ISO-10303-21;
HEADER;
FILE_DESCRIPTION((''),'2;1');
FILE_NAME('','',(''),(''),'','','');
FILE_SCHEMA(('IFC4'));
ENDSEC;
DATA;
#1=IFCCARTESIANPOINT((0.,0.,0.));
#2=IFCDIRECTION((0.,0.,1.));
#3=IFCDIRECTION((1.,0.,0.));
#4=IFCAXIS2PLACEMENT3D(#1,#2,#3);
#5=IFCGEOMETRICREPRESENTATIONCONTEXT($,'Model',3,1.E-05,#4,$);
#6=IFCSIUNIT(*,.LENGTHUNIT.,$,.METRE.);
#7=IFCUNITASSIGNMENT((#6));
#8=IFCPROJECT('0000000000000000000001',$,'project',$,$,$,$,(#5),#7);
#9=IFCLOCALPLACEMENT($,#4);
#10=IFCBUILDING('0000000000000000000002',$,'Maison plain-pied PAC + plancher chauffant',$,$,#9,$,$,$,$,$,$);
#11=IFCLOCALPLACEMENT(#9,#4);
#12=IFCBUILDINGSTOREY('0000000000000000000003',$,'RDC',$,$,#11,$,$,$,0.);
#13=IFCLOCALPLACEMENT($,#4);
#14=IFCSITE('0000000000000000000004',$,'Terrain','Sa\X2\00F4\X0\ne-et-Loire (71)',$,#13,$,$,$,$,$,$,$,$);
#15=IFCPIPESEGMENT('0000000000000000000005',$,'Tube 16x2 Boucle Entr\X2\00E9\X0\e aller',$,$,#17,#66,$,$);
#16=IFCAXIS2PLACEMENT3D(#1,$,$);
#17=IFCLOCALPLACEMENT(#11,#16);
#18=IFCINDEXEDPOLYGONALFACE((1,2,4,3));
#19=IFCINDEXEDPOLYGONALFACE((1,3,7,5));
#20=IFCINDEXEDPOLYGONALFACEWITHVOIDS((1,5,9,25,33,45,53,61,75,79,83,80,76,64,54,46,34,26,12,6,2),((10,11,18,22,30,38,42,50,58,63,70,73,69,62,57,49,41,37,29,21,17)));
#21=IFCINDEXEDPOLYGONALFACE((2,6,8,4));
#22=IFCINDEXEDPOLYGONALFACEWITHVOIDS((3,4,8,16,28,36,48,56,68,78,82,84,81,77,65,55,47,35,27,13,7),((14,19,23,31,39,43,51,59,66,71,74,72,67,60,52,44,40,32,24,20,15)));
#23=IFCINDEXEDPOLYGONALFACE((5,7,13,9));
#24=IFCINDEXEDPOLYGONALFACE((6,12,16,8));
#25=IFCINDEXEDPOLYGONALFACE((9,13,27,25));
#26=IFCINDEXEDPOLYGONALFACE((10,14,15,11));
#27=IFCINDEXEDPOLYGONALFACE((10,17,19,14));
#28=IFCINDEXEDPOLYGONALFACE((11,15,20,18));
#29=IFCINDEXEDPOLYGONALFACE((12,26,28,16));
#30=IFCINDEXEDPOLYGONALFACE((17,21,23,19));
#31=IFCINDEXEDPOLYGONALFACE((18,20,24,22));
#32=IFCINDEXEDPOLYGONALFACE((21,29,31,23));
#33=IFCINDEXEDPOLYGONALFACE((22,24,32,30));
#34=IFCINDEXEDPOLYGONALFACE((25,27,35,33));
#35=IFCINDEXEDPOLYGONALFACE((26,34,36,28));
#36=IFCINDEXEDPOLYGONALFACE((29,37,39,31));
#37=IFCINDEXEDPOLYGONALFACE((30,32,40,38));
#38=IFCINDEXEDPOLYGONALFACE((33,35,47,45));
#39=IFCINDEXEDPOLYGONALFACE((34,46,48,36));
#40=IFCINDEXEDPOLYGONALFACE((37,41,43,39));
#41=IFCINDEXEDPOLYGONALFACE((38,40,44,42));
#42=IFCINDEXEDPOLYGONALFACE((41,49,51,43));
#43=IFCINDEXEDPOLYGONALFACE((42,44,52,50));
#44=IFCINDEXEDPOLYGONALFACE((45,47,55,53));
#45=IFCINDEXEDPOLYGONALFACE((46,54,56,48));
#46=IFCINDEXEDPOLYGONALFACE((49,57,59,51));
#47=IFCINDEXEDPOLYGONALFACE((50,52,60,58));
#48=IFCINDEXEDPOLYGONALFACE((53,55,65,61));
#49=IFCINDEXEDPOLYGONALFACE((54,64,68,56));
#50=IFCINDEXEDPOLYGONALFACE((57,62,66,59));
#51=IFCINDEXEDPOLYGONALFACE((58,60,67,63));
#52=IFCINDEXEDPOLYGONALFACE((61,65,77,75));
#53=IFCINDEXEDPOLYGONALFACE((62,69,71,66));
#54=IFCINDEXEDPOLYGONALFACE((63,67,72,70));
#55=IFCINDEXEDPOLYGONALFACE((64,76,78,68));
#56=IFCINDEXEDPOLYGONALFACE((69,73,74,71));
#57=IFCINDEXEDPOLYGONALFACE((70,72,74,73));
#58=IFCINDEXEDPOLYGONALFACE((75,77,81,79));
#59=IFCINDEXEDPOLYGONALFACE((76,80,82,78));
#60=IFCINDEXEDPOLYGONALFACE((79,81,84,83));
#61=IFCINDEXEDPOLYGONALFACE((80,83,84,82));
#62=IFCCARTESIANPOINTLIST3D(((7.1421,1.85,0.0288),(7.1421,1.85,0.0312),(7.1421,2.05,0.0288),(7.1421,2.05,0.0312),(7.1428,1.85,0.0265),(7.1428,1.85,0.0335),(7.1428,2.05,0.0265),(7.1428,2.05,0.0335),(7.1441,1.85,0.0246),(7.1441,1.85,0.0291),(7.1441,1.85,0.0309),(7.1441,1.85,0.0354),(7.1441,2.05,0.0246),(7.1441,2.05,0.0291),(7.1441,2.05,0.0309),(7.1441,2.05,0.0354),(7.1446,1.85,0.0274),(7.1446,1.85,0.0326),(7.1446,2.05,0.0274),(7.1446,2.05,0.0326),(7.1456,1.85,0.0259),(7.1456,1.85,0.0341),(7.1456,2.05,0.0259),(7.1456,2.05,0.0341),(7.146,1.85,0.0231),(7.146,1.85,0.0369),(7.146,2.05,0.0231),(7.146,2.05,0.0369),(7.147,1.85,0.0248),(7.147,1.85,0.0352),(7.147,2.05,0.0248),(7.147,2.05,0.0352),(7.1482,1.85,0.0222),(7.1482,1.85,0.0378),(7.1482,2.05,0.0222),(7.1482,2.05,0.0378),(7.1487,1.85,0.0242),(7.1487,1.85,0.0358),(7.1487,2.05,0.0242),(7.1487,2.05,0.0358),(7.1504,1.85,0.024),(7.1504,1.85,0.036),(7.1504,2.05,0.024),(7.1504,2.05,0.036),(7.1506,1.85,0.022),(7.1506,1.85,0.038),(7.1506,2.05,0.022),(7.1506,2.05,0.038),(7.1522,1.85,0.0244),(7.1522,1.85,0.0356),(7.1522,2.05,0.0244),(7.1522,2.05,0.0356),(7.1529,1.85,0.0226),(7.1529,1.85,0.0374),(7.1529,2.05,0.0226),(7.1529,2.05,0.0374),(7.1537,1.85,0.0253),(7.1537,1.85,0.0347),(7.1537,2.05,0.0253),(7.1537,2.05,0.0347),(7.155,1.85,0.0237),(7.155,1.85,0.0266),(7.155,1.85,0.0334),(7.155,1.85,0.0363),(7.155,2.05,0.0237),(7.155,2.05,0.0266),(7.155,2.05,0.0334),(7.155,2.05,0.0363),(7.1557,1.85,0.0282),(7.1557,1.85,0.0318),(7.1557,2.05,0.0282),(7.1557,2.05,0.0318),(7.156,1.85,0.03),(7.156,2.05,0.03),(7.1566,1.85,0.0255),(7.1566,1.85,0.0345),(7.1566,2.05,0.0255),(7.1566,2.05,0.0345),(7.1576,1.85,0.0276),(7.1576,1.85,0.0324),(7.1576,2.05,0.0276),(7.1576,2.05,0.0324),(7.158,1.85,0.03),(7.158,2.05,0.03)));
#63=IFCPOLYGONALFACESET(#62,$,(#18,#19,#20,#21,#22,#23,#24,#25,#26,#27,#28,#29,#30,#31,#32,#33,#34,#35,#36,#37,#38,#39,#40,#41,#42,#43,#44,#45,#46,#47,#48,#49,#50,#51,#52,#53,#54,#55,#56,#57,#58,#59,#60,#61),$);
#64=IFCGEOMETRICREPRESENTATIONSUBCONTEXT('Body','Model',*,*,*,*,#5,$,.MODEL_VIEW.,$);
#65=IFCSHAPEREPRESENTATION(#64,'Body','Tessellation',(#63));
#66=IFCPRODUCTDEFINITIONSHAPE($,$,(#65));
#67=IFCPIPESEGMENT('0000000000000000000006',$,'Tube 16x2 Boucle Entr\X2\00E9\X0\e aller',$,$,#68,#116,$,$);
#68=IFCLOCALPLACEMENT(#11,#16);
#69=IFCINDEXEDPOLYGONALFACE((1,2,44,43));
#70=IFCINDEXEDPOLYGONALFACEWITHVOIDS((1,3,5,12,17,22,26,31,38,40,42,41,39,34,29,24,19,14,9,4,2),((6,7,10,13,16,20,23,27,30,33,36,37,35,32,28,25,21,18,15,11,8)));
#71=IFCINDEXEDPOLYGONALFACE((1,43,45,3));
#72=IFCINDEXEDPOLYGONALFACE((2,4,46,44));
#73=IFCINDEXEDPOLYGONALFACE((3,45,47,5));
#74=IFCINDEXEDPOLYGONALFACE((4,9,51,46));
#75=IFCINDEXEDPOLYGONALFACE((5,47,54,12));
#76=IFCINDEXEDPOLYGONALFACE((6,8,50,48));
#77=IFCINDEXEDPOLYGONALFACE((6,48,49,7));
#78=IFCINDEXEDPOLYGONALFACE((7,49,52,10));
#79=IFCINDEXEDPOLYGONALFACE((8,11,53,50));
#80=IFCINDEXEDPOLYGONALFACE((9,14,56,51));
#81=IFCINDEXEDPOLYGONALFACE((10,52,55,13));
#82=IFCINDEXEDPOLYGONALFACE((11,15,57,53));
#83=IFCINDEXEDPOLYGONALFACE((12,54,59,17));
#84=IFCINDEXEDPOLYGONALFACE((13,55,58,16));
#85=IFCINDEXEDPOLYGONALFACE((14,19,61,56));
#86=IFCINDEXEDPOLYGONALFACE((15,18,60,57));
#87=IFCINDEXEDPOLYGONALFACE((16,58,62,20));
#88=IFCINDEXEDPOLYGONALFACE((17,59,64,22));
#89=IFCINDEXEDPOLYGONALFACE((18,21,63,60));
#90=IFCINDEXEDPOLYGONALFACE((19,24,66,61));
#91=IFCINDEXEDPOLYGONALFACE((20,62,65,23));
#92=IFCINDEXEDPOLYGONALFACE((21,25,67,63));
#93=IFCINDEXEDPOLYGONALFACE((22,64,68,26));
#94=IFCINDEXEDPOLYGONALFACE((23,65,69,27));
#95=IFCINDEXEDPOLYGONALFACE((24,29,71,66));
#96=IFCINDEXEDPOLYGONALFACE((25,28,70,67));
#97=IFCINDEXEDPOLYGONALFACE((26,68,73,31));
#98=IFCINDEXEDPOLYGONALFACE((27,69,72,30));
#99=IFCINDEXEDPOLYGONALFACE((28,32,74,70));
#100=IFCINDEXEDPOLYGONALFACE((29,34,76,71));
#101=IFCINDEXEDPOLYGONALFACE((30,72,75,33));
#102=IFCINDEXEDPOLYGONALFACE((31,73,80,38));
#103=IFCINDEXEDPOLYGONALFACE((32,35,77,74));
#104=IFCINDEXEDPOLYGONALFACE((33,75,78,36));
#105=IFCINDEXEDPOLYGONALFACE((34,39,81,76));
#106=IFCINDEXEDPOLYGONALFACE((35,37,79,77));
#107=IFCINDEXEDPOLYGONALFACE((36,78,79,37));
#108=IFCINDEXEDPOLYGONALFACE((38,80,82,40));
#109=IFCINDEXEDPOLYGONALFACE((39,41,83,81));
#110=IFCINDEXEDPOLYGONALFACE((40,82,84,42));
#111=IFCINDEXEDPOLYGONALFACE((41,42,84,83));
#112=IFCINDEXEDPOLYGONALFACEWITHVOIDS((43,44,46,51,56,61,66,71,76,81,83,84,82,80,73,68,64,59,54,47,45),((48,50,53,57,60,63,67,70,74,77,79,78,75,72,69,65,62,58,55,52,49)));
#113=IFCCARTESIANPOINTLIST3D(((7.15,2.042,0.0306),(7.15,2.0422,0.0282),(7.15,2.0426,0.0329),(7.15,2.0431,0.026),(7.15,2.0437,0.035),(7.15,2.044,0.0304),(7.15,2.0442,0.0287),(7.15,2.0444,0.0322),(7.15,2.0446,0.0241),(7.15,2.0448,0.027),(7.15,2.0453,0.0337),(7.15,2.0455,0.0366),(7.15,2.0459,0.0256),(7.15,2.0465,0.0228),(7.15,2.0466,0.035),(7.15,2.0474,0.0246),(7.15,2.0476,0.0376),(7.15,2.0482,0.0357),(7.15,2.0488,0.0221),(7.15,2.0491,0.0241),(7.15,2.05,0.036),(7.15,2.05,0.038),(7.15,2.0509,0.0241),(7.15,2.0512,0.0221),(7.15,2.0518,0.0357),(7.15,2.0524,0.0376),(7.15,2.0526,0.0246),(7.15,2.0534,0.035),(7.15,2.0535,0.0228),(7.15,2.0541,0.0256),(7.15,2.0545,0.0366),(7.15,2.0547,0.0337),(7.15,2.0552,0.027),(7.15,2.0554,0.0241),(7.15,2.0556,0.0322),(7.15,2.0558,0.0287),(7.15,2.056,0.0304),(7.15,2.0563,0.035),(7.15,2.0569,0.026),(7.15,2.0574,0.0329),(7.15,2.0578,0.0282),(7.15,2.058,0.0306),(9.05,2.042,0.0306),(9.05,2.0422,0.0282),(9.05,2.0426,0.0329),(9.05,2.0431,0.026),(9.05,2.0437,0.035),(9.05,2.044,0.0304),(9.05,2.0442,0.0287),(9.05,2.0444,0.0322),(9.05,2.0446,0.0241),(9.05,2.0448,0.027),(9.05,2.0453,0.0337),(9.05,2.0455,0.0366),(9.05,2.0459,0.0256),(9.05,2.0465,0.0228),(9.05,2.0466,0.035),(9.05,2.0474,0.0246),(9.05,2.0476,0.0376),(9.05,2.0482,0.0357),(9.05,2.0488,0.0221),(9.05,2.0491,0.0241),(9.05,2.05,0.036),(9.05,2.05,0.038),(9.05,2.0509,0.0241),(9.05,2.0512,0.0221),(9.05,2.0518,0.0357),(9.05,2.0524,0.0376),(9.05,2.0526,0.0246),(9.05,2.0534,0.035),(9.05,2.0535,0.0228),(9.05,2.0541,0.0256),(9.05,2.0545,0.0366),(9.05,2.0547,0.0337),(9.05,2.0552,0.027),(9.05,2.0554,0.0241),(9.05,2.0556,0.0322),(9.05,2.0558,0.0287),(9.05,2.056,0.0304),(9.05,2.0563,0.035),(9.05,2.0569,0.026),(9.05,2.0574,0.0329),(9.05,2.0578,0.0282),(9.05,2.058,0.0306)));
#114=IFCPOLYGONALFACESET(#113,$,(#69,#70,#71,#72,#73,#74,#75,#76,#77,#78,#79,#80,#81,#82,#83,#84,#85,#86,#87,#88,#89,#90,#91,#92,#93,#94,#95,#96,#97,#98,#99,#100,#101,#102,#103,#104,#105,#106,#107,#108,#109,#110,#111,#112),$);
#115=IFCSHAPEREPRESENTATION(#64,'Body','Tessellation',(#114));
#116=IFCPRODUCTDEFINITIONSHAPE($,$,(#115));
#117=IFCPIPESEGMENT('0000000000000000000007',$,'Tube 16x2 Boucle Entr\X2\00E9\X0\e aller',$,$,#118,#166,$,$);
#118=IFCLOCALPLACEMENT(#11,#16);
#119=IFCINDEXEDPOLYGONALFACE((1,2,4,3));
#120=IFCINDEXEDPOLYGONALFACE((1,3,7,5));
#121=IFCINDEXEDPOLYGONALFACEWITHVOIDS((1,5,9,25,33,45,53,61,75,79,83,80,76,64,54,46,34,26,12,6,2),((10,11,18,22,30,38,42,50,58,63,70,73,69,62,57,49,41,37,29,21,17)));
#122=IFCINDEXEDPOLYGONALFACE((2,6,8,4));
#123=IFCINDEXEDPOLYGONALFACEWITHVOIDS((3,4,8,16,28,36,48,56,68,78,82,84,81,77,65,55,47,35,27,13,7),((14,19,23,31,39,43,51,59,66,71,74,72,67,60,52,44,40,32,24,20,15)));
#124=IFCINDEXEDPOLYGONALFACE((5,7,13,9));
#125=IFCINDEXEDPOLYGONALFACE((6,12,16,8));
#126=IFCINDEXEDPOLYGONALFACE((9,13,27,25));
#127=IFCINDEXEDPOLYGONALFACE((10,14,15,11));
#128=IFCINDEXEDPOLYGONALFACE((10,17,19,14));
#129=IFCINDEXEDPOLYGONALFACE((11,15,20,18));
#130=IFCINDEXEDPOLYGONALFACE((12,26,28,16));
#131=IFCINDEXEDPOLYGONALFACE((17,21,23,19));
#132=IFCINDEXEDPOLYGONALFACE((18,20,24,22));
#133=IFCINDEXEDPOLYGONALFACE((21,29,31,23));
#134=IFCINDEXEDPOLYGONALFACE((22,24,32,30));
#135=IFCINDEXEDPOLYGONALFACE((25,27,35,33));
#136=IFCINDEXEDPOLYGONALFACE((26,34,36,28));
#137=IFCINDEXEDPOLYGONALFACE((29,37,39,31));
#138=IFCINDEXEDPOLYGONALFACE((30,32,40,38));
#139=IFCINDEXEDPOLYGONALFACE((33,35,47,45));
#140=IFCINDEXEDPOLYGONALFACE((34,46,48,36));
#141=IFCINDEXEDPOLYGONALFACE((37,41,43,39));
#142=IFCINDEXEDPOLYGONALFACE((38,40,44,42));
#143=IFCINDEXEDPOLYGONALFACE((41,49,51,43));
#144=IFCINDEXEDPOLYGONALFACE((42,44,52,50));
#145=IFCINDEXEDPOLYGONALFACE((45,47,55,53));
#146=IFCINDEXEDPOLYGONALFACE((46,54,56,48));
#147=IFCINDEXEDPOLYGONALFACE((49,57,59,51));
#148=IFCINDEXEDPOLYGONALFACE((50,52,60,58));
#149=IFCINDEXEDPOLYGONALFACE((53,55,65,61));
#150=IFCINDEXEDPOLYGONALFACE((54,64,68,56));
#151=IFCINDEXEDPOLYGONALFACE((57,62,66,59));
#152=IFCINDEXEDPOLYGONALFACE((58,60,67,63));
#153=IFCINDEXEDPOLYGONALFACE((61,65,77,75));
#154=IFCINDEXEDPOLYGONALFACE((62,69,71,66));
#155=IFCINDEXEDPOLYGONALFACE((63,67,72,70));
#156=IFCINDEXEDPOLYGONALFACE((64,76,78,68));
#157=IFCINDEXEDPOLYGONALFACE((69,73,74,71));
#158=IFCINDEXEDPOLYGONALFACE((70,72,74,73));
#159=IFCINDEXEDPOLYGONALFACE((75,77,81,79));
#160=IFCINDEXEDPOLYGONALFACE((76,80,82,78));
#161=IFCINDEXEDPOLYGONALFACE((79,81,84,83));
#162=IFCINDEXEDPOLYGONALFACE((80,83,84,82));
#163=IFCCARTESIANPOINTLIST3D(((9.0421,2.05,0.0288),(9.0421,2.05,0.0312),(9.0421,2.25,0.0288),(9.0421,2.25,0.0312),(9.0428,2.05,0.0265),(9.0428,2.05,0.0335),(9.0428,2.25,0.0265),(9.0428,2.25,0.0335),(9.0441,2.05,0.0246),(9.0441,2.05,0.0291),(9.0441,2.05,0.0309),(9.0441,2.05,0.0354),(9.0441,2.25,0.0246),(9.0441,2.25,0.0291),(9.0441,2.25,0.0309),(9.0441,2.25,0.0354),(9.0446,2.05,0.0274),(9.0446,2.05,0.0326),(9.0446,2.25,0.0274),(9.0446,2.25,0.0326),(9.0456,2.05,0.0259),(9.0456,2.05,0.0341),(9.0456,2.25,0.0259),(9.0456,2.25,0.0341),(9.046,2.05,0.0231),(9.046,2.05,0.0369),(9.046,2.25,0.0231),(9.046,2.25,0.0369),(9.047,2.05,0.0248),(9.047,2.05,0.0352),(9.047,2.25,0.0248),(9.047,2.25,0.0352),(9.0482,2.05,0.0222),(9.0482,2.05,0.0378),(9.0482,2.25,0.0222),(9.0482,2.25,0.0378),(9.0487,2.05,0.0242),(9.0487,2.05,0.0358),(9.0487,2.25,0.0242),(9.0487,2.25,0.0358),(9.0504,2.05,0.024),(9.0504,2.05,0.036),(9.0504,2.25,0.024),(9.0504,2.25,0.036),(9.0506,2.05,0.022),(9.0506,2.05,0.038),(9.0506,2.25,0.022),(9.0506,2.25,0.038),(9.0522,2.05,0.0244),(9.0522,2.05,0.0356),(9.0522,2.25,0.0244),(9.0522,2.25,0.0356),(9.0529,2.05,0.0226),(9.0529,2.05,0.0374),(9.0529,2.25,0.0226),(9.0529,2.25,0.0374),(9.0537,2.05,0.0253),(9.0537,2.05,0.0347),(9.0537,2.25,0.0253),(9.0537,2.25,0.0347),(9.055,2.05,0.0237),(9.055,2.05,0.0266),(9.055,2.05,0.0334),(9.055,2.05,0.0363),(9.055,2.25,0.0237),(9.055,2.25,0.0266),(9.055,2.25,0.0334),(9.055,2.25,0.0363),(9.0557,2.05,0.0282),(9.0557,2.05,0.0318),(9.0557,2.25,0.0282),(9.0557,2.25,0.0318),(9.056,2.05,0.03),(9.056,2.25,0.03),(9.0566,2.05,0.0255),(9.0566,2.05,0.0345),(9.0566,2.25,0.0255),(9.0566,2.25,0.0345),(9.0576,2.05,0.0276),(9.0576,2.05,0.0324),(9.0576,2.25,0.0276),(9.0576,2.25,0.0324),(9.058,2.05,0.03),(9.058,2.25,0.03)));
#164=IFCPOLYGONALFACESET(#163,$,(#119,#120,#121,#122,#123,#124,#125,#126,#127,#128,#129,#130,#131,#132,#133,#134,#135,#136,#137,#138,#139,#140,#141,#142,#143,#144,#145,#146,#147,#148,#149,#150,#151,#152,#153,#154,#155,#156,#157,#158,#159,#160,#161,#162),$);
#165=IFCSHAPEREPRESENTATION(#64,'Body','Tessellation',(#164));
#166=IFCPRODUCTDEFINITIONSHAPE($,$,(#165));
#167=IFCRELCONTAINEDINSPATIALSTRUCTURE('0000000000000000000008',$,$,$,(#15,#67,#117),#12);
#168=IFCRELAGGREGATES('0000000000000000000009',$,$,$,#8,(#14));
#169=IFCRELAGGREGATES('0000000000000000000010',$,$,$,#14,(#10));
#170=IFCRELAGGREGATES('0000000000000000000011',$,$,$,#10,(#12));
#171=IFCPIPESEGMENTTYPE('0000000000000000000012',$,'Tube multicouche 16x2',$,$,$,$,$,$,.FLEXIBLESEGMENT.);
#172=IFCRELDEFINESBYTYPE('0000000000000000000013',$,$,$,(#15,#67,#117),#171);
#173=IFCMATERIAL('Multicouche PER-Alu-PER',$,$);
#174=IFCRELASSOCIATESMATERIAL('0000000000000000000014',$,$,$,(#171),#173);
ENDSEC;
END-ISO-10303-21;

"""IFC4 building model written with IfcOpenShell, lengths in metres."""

from ifc_helpers import new_model, si_unit, frame, origin_with_axes, place, context, subcontext, project, spatial, hollow_circle, extrude, material, type_object, element, save


model = new_model("IFC4")

# Units and contexts
model_context = context("Model", 3, precision=1e-05, world=origin_with_axes())
body_context = subcontext(model_context, "Body", "Model", "MODEL_VIEW")
ifc_project = project(units=[si_unit("LENGTHUNIT", "METRE")], contexts=[model_context])

# Site, building, storey
site_placement = place(None, origin_with_axes())
site = spatial("IfcSite", under=ifc_project, at=site_placement, Name="Terrain", Description="Saône-et-Loire (71)")
building_placement = place(None, origin_with_axes())
building = spatial("IfcBuilding", under=site, at=building_placement, Name="Maison plain-pied PAC + plancher chauffant")
storey_placement = place(building_placement, origin_with_axes())
storey = spatial("IfcBuildingStorey", under=building, at=storey_placement, Name="RDC", Elevation=0.0)

# Pipe segments
ifc_material_1 = material(Name="Multicouche PER-Alu-PER")
pipe_segment_type = type_object("IfcPipeSegmentType", Name="Tube multicouche 16x2", PredefinedType="FLEXIBLESEGMENT", material=ifc_material_1)
pipe_segment_1_placement = place(storey_placement, frame((7.15, 1.85, 0.03), z_axis=(0.0, 1.0, 0.0), x_axis=(1.0, 0.0, 0.0)))
element("IfcPipeSegment", 1, at=pipe_segment_1_placement, inside=storey, type_object=pipe_segment_type, Name="Tube 16x2 Boucle Entrée aller", context=body_context, shape_type="SweptSolid", body=[
    extrude(hollow_circle(Radius=0.008, WallThickness=0.002), origin_with_axes(), (0.0, 0.0, 1.0), 0.2),
])
pipe_segment_2_placement = place(storey_placement, frame((7.15, 2.05, 0.03), z_axis=(1.0, 0.0, 0.0), x_axis=(0.0, 0.0, 1.0)))
element("IfcPipeSegment", 2, at=pipe_segment_2_placement, inside=storey, type_object=pipe_segment_type, Name="Tube 16x2 Boucle Entrée aller", context=body_context, shape_type="SweptSolid", body=[
    extrude(hollow_circle(Radius=0.008, WallThickness=0.002), origin_with_axes(), (0.0, 0.0, 1.0), 1.9),
])
pipe_segment_3_placement = place(storey_placement, frame((9.05, 2.05, 0.03), z_axis=(0.0, 1.0, 0.0), x_axis=(1.0, 0.0, 0.0)))
element("IfcPipeSegment", 3, at=pipe_segment_3_placement, inside=storey, type_object=pipe_segment_type, Name="Tube 16x2 Boucle Entrée aller", context=body_context, shape_type="SweptSolid", body=[
    extrude(hollow_circle(Radius=0.008, WallThickness=0.002), origin_with_axes(), (0.0, 0.0, 1.0), 0.2),
])

save(model, "model.ifc")
